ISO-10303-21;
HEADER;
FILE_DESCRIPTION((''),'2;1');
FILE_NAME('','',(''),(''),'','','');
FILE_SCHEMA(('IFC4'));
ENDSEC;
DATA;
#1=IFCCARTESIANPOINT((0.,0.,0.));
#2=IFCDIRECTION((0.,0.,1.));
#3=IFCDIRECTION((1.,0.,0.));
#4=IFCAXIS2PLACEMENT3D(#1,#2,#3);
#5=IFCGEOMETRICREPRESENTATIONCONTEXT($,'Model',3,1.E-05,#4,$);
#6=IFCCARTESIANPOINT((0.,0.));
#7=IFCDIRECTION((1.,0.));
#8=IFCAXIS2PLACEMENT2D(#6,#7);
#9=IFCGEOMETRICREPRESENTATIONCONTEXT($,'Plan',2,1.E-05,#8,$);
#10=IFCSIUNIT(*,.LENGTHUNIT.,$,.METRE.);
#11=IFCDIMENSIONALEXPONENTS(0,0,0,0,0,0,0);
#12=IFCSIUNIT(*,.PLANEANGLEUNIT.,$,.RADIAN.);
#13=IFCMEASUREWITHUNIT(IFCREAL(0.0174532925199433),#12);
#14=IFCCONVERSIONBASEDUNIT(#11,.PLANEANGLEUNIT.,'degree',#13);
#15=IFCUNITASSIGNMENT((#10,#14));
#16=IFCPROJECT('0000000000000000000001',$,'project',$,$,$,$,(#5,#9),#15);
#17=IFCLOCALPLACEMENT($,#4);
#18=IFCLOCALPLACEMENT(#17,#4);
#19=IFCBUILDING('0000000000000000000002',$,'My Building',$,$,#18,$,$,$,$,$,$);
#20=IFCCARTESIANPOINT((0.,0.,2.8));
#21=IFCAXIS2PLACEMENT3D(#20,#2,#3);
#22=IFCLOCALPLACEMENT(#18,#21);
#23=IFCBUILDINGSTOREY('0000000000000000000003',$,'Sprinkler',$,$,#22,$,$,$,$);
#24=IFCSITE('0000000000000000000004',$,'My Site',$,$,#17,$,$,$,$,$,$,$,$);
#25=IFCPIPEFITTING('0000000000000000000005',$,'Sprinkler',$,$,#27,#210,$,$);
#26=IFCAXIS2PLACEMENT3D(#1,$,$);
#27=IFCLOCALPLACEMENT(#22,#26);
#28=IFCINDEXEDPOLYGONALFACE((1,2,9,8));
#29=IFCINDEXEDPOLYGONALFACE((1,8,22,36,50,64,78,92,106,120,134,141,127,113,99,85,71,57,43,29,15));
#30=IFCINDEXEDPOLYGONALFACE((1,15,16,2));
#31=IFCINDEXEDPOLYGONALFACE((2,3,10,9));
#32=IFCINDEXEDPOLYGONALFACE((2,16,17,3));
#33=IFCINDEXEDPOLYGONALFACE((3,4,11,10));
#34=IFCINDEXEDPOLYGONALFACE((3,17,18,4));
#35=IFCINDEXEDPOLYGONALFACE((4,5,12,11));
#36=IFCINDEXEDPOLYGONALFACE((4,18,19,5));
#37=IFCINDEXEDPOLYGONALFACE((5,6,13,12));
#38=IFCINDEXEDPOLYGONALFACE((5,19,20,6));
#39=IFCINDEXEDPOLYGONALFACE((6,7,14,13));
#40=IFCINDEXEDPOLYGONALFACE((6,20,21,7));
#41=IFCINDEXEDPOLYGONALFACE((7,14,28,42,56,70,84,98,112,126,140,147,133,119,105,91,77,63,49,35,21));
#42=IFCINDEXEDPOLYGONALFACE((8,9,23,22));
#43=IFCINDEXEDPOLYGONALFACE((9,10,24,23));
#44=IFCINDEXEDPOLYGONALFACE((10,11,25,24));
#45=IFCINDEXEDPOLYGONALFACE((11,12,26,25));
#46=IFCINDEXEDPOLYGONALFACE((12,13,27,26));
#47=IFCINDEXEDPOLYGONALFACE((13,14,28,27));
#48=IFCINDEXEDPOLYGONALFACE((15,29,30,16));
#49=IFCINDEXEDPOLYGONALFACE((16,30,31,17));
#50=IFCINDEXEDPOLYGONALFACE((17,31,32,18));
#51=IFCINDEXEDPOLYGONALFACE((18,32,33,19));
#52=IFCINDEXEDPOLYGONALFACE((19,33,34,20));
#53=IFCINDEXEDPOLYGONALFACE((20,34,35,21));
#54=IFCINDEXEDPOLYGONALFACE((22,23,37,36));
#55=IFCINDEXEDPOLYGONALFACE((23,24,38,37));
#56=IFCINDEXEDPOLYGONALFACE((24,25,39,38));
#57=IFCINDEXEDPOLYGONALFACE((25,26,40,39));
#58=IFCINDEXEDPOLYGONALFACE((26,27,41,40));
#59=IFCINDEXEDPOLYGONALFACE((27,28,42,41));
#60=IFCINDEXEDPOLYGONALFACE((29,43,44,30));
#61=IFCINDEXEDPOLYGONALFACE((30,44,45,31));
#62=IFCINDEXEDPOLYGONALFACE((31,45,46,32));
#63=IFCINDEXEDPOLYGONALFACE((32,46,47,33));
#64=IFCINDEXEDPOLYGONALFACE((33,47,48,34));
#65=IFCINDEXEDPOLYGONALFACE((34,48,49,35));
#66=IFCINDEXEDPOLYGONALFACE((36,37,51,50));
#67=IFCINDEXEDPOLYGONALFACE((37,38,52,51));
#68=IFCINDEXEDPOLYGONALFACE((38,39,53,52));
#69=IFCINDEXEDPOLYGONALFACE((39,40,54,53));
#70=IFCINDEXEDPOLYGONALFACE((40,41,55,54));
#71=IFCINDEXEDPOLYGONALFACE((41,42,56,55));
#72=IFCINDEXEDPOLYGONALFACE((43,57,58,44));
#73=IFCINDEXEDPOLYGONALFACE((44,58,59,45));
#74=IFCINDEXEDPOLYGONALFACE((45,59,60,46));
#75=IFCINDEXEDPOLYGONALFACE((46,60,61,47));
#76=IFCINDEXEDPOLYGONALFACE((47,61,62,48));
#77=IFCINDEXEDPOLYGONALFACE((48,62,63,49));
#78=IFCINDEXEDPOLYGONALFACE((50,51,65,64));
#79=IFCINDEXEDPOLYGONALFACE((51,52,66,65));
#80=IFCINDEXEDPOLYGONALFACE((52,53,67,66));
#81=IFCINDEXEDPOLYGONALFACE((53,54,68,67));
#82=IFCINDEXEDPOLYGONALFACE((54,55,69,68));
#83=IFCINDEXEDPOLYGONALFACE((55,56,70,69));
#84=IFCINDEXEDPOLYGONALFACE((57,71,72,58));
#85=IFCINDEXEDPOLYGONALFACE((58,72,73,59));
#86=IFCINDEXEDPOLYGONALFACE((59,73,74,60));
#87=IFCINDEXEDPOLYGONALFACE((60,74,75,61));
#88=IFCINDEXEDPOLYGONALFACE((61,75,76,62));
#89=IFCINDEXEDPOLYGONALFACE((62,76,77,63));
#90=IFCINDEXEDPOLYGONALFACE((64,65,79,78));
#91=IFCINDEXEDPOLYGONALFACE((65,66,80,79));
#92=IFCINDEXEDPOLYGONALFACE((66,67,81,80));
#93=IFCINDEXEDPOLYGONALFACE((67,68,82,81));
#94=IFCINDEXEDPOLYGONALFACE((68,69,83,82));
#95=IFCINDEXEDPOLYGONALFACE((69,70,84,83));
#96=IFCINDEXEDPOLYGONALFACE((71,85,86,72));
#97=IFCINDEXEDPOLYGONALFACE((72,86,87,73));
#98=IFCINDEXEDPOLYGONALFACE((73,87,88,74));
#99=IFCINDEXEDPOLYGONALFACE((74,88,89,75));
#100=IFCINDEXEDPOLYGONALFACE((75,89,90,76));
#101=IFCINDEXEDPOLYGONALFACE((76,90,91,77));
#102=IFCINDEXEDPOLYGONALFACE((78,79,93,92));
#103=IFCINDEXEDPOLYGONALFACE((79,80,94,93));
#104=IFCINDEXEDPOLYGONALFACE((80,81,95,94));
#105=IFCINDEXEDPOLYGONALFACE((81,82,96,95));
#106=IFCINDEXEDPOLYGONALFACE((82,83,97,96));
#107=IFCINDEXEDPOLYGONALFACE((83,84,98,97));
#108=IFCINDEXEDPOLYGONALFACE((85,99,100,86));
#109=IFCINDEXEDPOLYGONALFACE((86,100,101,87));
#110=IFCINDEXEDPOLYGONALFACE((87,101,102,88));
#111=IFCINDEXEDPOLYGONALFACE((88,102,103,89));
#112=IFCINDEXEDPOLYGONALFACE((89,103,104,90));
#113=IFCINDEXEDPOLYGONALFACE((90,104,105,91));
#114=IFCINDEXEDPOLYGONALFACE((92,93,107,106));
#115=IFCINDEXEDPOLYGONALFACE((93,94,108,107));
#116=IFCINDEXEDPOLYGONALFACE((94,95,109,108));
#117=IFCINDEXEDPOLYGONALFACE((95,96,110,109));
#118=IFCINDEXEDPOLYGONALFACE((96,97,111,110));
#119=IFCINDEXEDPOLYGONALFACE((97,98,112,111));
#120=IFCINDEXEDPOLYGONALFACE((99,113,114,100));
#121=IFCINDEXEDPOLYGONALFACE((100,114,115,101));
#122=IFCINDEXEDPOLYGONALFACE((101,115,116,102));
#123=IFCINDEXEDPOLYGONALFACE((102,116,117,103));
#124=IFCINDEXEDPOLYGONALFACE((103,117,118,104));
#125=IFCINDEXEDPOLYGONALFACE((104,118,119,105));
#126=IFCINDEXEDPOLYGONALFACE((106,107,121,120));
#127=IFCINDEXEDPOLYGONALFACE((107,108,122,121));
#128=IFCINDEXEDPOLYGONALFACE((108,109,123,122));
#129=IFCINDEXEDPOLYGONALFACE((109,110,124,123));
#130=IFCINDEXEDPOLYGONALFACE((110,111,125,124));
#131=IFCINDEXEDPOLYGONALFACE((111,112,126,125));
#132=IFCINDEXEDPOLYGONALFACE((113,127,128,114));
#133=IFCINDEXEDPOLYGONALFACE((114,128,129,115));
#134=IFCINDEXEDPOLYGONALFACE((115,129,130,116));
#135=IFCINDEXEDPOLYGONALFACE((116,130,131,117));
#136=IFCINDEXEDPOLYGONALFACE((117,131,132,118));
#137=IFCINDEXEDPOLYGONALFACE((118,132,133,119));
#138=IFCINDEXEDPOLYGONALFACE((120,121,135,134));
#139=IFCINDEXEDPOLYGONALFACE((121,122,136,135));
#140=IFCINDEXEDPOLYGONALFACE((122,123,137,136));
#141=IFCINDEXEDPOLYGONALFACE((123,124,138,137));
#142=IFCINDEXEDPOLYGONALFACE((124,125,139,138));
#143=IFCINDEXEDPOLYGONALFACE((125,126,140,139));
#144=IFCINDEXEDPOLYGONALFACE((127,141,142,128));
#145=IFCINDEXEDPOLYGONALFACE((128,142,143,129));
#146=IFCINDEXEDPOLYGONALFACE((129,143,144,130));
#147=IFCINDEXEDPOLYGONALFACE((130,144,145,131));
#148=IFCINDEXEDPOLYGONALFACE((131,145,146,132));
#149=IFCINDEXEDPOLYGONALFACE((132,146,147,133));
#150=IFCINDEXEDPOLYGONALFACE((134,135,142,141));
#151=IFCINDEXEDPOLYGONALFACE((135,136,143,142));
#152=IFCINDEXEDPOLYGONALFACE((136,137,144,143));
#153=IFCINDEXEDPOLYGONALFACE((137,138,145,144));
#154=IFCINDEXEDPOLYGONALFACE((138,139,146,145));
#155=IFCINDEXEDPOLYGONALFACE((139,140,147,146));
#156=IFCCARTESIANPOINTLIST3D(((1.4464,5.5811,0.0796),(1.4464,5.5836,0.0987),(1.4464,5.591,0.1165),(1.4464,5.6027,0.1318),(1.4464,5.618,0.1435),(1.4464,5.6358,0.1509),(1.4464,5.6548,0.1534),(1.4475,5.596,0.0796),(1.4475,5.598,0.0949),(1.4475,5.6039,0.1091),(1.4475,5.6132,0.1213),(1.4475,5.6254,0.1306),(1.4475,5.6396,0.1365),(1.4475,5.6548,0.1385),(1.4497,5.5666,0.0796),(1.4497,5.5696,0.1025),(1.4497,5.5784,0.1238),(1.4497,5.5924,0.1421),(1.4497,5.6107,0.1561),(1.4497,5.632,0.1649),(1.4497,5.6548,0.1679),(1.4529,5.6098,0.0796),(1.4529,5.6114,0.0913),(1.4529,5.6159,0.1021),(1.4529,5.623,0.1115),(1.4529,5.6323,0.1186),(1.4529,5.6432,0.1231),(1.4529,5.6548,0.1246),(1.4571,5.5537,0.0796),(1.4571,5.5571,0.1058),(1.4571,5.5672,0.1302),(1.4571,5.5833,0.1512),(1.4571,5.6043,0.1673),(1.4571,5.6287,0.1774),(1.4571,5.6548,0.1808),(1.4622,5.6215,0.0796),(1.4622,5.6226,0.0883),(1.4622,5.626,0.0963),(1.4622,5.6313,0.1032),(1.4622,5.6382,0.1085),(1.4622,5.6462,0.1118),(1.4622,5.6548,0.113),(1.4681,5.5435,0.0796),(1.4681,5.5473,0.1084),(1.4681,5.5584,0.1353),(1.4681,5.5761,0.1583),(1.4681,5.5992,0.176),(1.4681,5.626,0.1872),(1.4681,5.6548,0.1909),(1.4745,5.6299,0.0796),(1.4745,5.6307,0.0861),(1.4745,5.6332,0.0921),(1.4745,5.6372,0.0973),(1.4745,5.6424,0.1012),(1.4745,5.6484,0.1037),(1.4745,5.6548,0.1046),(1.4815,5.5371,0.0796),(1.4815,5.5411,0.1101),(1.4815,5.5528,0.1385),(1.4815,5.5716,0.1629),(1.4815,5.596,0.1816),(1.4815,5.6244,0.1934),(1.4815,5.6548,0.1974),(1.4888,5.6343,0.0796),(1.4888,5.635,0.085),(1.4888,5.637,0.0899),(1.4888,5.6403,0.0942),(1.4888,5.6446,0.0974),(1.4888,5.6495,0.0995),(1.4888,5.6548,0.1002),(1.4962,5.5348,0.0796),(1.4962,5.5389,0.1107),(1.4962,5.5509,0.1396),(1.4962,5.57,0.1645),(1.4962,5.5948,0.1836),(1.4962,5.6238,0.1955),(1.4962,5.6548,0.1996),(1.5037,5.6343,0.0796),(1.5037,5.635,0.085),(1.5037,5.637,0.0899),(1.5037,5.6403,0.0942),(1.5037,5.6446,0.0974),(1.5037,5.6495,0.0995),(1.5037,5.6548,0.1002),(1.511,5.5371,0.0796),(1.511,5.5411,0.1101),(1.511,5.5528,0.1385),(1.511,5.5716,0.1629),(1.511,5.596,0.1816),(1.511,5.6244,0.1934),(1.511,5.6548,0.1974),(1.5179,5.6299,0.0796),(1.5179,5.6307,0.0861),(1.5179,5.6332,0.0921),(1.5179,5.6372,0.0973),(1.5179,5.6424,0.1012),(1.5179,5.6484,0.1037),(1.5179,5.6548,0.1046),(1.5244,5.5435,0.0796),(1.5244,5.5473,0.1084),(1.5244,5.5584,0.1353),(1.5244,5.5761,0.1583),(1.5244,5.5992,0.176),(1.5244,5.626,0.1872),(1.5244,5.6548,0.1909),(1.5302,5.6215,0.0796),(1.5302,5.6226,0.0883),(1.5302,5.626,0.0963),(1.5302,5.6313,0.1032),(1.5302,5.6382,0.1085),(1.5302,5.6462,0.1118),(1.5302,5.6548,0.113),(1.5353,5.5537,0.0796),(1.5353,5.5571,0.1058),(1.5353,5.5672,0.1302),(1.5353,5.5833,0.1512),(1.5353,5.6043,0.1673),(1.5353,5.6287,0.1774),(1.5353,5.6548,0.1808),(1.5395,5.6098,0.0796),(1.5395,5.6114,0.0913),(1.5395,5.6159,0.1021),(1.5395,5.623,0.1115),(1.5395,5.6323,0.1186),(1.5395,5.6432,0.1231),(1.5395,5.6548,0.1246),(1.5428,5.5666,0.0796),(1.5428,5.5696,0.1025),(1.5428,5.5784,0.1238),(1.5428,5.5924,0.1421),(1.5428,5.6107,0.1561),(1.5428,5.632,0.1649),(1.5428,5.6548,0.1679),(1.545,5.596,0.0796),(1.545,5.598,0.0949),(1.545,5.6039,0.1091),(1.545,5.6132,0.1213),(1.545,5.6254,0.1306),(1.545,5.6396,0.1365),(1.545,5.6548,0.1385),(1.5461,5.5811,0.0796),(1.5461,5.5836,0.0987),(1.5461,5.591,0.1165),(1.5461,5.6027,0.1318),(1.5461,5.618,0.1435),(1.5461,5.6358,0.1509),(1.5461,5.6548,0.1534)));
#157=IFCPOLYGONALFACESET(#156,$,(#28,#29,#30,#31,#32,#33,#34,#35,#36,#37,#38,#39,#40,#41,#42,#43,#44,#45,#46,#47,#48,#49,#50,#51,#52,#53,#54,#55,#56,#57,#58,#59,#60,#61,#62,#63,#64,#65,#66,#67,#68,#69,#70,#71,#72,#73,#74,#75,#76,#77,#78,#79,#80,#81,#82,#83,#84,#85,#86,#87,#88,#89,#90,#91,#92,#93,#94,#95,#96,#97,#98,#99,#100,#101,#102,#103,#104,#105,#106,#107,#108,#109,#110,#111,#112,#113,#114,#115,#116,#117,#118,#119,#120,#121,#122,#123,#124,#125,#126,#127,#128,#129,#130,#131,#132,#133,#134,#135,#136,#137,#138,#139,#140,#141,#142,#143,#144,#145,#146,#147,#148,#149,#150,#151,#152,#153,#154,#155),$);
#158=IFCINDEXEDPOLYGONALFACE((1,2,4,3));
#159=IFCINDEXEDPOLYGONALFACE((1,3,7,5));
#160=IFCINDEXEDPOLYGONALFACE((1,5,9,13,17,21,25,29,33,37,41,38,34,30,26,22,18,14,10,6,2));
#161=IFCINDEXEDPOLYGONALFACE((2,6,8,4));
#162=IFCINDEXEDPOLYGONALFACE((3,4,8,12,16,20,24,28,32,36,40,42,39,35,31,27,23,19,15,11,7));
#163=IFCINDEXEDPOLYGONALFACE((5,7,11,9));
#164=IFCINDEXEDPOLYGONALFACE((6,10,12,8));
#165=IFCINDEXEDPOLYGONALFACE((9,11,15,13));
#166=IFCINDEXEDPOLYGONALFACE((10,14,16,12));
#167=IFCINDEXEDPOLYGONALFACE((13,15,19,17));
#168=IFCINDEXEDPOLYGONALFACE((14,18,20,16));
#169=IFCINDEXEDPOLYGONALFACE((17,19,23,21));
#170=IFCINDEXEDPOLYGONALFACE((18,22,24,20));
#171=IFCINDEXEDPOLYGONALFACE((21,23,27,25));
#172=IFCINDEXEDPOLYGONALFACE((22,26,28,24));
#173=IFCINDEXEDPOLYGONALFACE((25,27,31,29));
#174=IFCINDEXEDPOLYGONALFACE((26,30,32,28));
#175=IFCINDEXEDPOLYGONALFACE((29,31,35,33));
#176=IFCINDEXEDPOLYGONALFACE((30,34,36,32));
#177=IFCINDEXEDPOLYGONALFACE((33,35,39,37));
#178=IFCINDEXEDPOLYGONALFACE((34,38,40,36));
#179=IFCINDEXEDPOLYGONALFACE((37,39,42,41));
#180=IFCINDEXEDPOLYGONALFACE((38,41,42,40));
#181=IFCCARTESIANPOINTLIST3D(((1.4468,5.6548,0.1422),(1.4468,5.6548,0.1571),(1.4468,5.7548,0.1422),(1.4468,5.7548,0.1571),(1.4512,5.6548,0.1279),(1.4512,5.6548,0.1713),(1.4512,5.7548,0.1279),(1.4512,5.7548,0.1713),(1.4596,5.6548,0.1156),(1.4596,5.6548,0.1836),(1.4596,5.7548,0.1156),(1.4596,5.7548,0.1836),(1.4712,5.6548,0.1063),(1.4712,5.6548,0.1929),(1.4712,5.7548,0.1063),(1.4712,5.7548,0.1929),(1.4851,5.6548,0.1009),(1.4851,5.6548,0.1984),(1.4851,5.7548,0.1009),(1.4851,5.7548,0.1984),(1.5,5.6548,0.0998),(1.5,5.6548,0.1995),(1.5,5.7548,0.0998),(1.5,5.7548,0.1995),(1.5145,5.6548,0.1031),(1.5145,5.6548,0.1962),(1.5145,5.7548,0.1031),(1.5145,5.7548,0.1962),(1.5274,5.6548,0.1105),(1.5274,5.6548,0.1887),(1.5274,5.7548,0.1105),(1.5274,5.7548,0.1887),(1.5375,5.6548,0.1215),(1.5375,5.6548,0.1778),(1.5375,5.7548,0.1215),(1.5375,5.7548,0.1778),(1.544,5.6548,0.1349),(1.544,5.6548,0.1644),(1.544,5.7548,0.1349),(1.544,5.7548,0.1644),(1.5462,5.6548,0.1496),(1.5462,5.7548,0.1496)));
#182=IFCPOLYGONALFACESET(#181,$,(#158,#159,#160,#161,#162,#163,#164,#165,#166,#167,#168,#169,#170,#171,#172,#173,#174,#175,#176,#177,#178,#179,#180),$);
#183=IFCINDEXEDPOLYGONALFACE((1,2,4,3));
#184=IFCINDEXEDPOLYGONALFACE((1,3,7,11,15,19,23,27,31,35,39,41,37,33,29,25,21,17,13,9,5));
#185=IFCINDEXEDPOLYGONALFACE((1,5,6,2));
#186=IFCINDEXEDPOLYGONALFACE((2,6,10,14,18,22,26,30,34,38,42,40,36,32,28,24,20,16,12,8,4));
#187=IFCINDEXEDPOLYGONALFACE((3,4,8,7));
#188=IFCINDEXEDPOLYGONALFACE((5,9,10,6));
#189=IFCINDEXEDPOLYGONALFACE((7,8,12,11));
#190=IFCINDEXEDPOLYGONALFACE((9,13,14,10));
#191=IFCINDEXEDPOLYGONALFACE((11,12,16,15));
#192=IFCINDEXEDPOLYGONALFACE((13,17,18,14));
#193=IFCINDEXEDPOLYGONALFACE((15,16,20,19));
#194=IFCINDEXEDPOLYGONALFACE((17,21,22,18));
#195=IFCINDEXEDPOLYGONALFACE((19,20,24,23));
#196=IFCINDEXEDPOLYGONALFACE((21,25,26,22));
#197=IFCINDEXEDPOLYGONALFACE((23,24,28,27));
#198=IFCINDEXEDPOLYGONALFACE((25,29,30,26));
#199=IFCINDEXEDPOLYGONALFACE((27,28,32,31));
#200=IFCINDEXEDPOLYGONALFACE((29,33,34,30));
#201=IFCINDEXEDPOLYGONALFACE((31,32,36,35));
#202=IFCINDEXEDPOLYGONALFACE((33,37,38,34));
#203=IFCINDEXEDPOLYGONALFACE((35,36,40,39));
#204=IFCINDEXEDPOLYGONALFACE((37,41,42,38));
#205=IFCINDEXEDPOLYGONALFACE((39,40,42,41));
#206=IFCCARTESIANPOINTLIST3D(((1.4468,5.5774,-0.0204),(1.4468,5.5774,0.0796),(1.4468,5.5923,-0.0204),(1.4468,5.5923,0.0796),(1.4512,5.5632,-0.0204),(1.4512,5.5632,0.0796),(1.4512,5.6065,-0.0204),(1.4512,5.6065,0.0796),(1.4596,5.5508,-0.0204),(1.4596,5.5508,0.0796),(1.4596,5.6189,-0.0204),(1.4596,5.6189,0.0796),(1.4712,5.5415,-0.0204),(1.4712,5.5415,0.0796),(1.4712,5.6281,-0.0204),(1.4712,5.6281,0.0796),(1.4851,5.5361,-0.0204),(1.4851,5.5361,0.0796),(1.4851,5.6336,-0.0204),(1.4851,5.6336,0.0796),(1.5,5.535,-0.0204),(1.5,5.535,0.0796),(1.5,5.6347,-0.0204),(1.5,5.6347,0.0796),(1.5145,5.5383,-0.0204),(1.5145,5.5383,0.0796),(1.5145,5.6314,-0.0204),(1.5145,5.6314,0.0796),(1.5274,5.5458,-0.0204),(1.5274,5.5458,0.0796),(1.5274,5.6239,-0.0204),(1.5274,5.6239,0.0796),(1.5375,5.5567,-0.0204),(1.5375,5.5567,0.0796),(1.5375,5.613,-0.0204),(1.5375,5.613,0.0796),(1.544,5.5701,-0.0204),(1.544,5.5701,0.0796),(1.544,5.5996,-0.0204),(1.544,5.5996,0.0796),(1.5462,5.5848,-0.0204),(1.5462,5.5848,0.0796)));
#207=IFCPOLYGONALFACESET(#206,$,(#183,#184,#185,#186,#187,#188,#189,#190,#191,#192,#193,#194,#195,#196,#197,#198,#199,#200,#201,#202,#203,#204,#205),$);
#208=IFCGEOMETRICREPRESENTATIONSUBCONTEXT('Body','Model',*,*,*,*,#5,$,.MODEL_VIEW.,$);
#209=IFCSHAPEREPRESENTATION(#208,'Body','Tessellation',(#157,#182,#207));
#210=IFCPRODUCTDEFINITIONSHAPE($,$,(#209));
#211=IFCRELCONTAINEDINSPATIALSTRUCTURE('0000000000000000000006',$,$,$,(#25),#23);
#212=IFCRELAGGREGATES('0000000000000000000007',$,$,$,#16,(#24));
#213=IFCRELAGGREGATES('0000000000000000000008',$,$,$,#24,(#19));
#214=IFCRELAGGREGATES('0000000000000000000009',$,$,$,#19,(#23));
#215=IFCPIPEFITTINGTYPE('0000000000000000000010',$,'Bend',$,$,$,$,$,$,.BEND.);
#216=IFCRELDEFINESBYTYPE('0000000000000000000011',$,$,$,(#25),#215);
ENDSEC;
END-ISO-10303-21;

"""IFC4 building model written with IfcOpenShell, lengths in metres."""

from ifc_helpers import new_model, entity, si_unit, converted_unit, frame, origin_with_axes, origin_2d_with_axis, place, context, subcontext, project, spatial, circle, extrude, source, transform, mapped, type_object, type_shapes, element, save


model = new_model("IFC4")

# Units and contexts
model_context = context("Model", 3, precision=1e-05, world=origin_with_axes())
plan_context = context("Plan", 2, precision=1e-05, world=origin_2d_with_axis())
body_context = subcontext(model_context, "Body", "Model", "MODEL_VIEW")
ifc_project = project(units=[si_unit("LENGTHUNIT", "METRE"), converted_unit("PLANEANGLEUNIT", "degree", entity("IfcReal", 0.0174532925199433), si_unit("PLANEANGLEUNIT", "RADIAN"), dimensions=[0, 0, 0, 0, 0, 0, 0])], contexts=[model_context, plan_context])

# Site, building, storey
site_placement = place(None, origin_with_axes())
site = spatial("IfcSite", under=ifc_project, at=site_placement, Name="My Site")
building_placement = place(site_placement, origin_with_axes())
building = spatial("IfcBuilding", under=site, at=building_placement, Name="My Building")
storey_placement = place(building_placement, frame((0.0, 0.0, 2.8), z_axis=(0.0, 0.0, 1.0), x_axis=(1.0, 0.0, 0.0)))
storey = spatial("IfcBuildingStorey", under=building, at=storey_placement, Name="Sprinkler")

# Pipe fitting
pipe_fitting_type_1 = type_object("IfcPipeFittingType", Name="Bend", PredefinedType="BEND")
shared_shape_1 = source(origin_with_axes(), body_context, "Body", "SolidModel", [
    entity("IfcSweptDiskSolid", entity("IfcIndexedPolyCurve", entity("IfcCartesianPointList3D", [[0.0, 0.0, 0.1], [0.0, -0.0205, 0.1495], [0.0, -0.07, 0.17]]), [entity("IfcArcIndex", [1, 2, 3])]), 0.05),
    extrude(circle(Radius=0.05), origin_with_axes(), (0.0, 0.0, 1.0), 0.1),
    extrude(circle(Radius=0.05), frame((0.0, -0.07, 0.17), z_axis=(0.0, -1.0, 0.0), x_axis=(1.0, 0.0, 0.0)), (0.0, 0.0, 1.0), 0.1),
])
type_shapes(pipe_fitting_type_1, [shared_shape_1])
for number, where, z_axis, x_axis, name in (
    (1, (1.4962, 5.7548, 0.1496), (0.0, -1.0, 0.0), (1.0, 0.0, 0.0), "Sprinkler"),
):
    element("IfcPipeFitting", number, at=place(storey_placement, frame(where, z_axis=z_axis, x_axis=x_axis)), inside=storey, type_object=pipe_fitting_type_1, Name=name, context=body_context, shape_type="MappedRepresentation", body=[
        mapped(shared_shape_1, transform((0.0, 0.0, 0.0), x_axis=(1.0, 0.0, 0.0), y_axis=(0.0, 1.0, 0.0), z_axis=(0.0, 0.0, 1.0), scale=1.0)),
    ])

save(model, "model.ifc")
